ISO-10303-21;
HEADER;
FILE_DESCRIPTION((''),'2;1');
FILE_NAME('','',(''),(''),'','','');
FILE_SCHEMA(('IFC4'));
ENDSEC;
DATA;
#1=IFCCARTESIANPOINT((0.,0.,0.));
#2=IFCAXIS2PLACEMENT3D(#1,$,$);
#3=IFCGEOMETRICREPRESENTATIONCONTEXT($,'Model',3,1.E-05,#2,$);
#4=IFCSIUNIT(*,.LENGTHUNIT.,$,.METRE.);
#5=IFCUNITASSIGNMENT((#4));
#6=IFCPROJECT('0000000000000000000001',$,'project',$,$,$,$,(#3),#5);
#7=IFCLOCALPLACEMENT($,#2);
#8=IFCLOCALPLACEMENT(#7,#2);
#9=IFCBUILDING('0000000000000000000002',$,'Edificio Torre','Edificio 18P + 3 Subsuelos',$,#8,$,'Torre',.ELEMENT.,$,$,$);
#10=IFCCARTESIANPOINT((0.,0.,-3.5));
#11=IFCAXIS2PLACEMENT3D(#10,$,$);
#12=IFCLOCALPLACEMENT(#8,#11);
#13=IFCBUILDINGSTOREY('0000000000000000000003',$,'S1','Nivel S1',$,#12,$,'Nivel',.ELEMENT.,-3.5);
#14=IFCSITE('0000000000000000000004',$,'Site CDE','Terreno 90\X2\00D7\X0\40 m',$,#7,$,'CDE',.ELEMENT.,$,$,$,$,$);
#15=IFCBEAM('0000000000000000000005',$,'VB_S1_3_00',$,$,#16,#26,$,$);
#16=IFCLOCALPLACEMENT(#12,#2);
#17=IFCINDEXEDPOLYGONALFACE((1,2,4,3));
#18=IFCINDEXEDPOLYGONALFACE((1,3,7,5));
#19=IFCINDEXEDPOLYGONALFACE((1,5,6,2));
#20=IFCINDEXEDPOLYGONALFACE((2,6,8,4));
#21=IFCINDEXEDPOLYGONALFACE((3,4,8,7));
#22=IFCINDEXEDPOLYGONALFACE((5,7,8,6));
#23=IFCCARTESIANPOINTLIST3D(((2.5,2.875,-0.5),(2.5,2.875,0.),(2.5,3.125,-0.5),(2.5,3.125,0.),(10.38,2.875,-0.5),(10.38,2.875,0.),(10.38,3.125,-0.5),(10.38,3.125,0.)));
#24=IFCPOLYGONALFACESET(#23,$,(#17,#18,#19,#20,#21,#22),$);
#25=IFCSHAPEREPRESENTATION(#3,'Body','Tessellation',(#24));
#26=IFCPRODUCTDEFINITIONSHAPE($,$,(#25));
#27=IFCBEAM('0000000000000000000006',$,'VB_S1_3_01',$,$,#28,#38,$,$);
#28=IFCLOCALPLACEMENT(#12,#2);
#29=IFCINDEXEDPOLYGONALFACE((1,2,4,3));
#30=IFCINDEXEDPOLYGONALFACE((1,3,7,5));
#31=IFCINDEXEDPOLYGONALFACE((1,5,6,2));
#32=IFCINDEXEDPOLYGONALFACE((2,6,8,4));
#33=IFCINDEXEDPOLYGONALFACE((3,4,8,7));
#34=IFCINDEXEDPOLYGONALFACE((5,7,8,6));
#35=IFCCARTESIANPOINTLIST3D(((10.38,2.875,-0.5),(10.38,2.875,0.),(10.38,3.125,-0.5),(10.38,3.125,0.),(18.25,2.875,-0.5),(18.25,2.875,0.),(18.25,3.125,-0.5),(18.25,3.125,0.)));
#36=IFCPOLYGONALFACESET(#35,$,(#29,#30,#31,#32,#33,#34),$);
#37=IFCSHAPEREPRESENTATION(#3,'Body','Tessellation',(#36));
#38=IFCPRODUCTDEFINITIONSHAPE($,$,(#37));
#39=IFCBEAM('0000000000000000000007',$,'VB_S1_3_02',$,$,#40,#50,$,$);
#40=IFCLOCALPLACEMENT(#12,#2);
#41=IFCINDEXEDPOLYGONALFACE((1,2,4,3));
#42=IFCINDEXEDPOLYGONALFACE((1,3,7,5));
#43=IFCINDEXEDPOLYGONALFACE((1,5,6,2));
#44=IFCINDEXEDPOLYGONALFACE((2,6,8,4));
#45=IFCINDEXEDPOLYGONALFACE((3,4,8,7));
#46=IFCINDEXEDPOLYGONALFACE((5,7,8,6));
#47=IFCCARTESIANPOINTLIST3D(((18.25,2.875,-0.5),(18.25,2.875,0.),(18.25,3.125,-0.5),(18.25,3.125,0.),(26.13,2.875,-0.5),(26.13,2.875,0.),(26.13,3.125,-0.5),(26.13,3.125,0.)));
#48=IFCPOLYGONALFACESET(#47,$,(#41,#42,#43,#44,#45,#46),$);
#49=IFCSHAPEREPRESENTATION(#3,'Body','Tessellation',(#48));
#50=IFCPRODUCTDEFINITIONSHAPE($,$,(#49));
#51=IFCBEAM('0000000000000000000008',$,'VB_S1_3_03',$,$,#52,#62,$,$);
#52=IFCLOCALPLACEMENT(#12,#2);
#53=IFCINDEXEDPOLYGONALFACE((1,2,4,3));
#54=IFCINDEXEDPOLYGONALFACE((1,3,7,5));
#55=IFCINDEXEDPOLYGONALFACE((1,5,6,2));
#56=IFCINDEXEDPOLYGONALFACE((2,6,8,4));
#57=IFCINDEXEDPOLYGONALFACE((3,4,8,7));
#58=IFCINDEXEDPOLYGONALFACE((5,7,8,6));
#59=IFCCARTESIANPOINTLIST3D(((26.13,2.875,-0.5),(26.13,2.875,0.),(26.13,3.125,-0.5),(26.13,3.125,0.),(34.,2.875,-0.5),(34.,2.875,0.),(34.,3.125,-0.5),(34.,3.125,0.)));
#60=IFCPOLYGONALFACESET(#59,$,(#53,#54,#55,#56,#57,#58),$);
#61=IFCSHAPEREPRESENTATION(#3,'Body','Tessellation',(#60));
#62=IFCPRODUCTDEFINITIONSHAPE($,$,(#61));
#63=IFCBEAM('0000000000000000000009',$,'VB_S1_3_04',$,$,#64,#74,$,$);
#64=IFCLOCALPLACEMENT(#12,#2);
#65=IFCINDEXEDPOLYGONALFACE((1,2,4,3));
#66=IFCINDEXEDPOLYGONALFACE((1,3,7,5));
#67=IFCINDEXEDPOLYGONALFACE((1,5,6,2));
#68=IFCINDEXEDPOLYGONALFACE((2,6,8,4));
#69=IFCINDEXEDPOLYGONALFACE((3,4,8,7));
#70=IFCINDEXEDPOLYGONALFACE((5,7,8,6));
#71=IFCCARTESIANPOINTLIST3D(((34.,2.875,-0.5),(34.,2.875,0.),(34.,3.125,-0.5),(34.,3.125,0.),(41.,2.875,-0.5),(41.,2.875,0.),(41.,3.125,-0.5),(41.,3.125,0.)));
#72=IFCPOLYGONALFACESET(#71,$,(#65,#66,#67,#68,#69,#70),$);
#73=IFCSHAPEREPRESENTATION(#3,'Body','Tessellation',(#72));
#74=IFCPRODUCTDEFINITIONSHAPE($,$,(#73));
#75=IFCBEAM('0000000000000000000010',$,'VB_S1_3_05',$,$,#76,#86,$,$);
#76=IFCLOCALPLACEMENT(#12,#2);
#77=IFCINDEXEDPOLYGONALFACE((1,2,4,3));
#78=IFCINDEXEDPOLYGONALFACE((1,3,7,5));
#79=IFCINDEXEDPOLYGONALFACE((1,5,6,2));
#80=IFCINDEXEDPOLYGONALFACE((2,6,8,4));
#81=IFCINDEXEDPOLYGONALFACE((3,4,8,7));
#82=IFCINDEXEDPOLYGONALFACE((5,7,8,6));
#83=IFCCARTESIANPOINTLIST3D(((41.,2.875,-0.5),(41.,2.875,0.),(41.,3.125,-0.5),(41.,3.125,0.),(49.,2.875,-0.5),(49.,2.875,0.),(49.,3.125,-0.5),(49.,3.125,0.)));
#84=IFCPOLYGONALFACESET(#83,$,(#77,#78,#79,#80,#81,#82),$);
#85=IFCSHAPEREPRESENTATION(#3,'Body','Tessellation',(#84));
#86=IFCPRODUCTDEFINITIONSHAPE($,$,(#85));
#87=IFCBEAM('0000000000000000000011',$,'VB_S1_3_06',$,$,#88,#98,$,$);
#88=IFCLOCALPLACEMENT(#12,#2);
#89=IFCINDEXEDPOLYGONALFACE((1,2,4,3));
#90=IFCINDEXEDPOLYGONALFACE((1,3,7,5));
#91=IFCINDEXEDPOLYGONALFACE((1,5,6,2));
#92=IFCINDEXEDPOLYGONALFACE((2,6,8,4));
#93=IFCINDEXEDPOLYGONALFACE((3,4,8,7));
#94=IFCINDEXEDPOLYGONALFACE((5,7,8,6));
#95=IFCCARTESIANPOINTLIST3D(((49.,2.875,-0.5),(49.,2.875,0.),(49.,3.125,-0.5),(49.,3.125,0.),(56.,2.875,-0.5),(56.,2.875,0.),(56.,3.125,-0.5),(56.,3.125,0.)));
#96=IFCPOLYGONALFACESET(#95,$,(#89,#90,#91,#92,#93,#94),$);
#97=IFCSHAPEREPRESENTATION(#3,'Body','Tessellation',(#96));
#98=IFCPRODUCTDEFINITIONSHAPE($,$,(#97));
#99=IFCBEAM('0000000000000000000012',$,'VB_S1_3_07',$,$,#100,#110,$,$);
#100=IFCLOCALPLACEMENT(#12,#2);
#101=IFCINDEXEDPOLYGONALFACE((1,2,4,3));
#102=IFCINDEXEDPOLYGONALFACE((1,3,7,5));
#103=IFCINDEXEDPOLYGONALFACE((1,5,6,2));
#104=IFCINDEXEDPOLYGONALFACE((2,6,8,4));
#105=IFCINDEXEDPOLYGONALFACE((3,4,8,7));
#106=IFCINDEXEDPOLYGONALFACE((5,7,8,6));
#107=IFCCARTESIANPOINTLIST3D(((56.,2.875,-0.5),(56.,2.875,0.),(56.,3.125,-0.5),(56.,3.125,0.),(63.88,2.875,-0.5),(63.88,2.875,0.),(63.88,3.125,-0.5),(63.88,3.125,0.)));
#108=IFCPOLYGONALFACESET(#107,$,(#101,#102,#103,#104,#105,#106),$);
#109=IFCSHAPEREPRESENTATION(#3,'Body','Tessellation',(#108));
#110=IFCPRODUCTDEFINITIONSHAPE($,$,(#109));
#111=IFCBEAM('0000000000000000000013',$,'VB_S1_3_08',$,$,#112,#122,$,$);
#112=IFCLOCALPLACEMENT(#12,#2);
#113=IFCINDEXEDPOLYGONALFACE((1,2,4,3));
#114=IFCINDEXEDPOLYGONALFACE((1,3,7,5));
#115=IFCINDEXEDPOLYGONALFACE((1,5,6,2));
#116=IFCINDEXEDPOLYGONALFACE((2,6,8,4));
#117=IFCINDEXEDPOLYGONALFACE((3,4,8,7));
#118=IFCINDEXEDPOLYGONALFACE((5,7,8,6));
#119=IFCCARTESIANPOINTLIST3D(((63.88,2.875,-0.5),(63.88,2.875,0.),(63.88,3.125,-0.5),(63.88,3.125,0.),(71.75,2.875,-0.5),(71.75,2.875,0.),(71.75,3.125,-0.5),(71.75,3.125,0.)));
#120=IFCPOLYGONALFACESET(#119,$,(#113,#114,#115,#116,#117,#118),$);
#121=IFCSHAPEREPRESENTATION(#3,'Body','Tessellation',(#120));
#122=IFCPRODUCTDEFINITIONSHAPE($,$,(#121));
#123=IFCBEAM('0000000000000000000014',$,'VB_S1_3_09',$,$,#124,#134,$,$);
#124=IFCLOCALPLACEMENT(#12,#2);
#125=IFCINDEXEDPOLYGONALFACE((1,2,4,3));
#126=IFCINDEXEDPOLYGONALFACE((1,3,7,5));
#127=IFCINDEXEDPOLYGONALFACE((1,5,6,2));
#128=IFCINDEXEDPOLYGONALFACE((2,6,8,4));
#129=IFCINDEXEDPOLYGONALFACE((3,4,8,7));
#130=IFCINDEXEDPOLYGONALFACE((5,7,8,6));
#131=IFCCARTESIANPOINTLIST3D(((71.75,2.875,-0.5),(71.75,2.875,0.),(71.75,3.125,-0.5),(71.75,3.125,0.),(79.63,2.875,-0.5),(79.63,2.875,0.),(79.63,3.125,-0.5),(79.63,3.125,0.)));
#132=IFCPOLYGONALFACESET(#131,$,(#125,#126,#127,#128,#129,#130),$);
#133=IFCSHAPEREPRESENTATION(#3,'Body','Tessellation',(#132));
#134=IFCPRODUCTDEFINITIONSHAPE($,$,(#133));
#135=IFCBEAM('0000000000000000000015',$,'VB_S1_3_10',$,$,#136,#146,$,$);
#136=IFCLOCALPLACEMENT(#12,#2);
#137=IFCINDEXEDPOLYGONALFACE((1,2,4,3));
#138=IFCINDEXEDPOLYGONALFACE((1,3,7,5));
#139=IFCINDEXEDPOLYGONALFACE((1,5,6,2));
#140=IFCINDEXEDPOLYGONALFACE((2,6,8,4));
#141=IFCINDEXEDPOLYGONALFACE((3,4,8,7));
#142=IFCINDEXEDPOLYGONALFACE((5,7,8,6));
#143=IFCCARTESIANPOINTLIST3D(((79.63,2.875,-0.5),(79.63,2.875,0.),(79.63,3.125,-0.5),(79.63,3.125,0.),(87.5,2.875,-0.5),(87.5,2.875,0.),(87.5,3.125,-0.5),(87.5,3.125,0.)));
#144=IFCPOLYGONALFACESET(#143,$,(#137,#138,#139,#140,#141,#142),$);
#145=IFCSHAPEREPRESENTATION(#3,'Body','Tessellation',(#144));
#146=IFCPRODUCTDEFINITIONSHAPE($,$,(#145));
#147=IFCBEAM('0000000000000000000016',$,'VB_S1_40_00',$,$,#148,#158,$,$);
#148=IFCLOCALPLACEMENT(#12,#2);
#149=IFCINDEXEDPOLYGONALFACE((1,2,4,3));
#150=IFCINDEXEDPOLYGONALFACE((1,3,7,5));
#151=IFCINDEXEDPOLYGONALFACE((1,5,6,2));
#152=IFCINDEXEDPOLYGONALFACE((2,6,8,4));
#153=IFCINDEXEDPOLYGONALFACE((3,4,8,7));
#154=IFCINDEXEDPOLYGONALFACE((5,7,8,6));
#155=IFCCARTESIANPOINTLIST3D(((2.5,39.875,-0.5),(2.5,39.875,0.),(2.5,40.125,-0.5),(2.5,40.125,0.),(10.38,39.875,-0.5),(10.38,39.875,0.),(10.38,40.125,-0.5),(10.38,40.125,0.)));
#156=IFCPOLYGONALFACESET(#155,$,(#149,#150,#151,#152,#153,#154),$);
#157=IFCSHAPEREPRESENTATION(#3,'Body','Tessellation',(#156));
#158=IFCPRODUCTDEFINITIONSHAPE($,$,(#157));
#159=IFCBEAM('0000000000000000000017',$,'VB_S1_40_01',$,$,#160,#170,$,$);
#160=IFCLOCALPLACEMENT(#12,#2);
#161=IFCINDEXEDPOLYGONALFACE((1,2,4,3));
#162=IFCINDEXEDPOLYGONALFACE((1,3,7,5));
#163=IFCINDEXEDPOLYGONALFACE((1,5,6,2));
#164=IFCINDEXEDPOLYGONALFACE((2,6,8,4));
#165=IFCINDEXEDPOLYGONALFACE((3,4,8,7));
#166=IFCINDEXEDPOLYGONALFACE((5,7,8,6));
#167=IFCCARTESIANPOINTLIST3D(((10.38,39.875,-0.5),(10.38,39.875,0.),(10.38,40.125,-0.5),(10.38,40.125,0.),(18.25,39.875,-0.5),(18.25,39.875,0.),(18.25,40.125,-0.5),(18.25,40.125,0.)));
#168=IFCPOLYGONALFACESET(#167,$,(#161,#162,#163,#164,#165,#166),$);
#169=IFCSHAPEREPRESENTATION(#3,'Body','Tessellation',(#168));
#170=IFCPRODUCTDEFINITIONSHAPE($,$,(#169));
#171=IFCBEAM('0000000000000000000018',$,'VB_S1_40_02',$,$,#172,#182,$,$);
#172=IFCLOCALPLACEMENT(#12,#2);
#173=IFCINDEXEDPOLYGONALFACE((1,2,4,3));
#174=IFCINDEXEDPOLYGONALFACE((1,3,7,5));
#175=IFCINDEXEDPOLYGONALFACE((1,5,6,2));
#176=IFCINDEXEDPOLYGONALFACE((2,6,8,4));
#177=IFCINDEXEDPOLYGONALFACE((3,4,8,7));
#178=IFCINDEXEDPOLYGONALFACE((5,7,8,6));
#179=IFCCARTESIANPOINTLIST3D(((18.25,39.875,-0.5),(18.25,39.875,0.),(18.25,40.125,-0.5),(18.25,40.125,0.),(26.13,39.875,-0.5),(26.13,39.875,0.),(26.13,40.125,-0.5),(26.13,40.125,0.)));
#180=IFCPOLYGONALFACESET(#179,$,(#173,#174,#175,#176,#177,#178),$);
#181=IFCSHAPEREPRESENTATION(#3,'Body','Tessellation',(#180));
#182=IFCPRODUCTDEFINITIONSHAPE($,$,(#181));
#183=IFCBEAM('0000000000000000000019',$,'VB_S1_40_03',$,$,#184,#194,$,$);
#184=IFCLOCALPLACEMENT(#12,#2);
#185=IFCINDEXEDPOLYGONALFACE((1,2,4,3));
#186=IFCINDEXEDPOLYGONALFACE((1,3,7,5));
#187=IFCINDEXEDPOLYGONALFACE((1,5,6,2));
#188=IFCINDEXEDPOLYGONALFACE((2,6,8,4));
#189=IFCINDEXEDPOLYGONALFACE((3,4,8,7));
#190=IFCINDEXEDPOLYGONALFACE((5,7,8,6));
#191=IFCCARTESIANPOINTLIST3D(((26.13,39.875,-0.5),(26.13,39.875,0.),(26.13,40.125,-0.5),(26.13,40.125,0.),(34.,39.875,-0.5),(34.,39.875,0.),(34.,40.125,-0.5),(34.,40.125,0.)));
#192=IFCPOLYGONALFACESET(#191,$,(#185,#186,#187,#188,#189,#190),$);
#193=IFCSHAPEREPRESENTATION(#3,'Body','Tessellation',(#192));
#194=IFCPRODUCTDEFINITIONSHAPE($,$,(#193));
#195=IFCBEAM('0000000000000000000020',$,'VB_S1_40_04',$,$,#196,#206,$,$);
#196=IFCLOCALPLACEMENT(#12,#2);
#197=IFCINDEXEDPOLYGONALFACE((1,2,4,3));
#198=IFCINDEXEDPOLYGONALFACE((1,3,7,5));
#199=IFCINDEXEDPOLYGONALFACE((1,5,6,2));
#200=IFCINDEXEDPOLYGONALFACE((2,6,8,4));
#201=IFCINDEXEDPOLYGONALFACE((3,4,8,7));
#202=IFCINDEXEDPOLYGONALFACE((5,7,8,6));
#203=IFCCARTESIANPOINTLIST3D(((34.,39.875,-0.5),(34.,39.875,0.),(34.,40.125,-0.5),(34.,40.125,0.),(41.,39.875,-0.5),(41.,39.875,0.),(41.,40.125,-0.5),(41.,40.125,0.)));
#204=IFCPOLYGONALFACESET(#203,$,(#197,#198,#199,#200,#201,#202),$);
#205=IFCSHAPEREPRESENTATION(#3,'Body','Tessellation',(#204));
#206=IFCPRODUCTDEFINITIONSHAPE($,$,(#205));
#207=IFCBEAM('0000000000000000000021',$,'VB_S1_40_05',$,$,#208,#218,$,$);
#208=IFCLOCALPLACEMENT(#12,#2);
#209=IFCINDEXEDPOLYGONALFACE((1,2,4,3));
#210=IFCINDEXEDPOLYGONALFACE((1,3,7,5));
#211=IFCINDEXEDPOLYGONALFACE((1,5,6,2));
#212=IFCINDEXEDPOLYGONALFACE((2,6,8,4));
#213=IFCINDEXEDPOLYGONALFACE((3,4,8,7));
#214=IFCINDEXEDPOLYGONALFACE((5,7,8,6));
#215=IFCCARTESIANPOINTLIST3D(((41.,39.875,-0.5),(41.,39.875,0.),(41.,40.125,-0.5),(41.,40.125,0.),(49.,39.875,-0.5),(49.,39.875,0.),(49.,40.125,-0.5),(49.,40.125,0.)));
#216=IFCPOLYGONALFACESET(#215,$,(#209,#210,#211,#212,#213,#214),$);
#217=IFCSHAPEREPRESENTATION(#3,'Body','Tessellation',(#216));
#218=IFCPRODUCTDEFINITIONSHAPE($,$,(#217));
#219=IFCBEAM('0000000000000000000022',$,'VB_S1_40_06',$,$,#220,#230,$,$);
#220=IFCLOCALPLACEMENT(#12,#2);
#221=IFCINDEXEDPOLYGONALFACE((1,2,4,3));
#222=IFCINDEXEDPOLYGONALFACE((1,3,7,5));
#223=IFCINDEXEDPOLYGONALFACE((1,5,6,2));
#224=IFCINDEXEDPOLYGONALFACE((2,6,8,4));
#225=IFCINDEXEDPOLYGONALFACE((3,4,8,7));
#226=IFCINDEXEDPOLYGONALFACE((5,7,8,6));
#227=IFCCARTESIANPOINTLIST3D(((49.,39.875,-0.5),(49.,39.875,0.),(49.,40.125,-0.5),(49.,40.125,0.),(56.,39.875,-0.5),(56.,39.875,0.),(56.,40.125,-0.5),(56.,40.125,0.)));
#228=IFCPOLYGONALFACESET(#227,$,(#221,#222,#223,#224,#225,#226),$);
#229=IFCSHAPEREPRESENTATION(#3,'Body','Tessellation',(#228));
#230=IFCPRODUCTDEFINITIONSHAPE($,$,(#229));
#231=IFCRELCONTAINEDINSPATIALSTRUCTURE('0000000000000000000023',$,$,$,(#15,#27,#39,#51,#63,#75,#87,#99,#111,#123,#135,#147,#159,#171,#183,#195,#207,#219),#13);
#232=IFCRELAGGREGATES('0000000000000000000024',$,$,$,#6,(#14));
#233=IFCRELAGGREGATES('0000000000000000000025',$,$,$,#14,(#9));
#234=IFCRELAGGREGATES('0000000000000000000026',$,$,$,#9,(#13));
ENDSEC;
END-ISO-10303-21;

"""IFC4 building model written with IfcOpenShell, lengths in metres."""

from ifc_helpers import new_model, si_unit, frame, origin, origin_2d, place, context, project, spatial, rectangle, extrude, element, save


model = new_model("IFC4")

# Units and contexts
model_context = context("Model", 3, precision=1e-05, world=origin())
ifc_project = project(units=[si_unit("LENGTHUNIT", "METRE")], contexts=[model_context])

# Site, building, storey
site_placement = place(None, origin())
site = spatial("IfcSite", under=ifc_project, at=site_placement, Name="Site CDE", Description="Terreno 90×40 m", LongName="CDE", CompositionType="ELEMENT")
building_placement = place(site_placement, origin())
building = spatial("IfcBuilding", under=site, at=building_placement, Name="Edificio Torre", Description="Edificio 18P + 3 Subsuelos", LongName="Torre", CompositionType="ELEMENT")
storey_placement = place(building_placement, frame((0.0, 0.0, -3.5)))
storey = spatial("IfcBuildingStorey", under=building, at=storey_placement, Name="S1", Description="Nivel S1", LongName="Nivel", CompositionType="ELEMENT", Elevation=-3.5)

# Beams
beam_1_placement = place(storey_placement, frame((6.44, 3.0, -0.5)))
element("IfcBeam", 1, at=beam_1_placement, inside=storey, Name="VB_S1_3_00", context=model_context, shape_type="SweptSolid", body=[
    extrude(rectangle(XDim=7.88, YDim=0.25, at=origin_2d()), origin(), (0.0, 0.0, 1.0), 0.5),
])
beam_2_placement = place(storey_placement, frame((14.315, 3.0, -0.5)))
element("IfcBeam", 2, at=beam_2_placement, inside=storey, Name="VB_S1_3_01", context=model_context, shape_type="SweptSolid", body=[
    extrude(rectangle(XDim=7.87, YDim=0.25, at=origin_2d()), origin(), (0.0, 0.0, 1.0), 0.5),
])
beam_3_placement = place(storey_placement, frame((22.19, 3.0, -0.5)))
element("IfcBeam", 3, at=beam_3_placement, inside=storey, Name="VB_S1_3_02", context=model_context, shape_type="SweptSolid", body=[
    extrude(rectangle(XDim=7.88, YDim=0.25, at=origin_2d()), origin(), (0.0, 0.0, 1.0), 0.5),
])
beam_4_placement = place(storey_placement, frame((30.065, 3.0, -0.5)))
element("IfcBeam", 4, at=beam_4_placement, inside=storey, Name="VB_S1_3_03", context=model_context, shape_type="SweptSolid", body=[
    extrude(rectangle(XDim=7.87, YDim=0.25, at=origin_2d()), origin(), (0.0, 0.0, 1.0), 0.5),
])
beam_5_placement = place(storey_placement, frame((37.5, 3.0, -0.5)))
element("IfcBeam", 5, at=beam_5_placement, inside=storey, Name="VB_S1_3_04", context=model_context, shape_type="SweptSolid", body=[
    extrude(rectangle(XDim=7.0, YDim=0.25, at=origin_2d()), origin(), (0.0, 0.0, 1.0), 0.5),
])
beam_6_placement = place(storey_placement, frame((45.0, 3.0, -0.5)))
element("IfcBeam", 6, at=beam_6_placement, inside=storey, Name="VB_S1_3_05", context=model_context, shape_type="SweptSolid", body=[
    extrude(rectangle(XDim=8.0, YDim=0.25, at=origin_2d()), origin(), (0.0, 0.0, 1.0), 0.5),
])
beam_7_placement = place(storey_placement, frame((52.5, 3.0, -0.5)))
element("IfcBeam", 7, at=beam_7_placement, inside=storey, Name="VB_S1_3_06", context=model_context, shape_type="SweptSolid", body=[
    extrude(rectangle(XDim=7.0, YDim=0.25, at=origin_2d()), origin(), (0.0, 0.0, 1.0), 0.5),
])
beam_8_placement = place(storey_placement, frame((59.94, 3.0, -0.5)))
element("IfcBeam", 8, at=beam_8_placement, inside=storey, Name="VB_S1_3_07", context=model_context, shape_type="SweptSolid", body=[
    extrude(rectangle(XDim=7.88, YDim=0.25, at=origin_2d()), origin(), (0.0, 0.0, 1.0), 0.5),
])
beam_9_placement = place(storey_placement, frame((67.815, 3.0, -0.5)))
element("IfcBeam", 9, at=beam_9_placement, inside=storey, Name="VB_S1_3_08", context=model_context, shape_type="SweptSolid", body=[
    extrude(rectangle(XDim=7.87, YDim=0.25, at=origin_2d()), origin(), (0.0, 0.0, 1.0), 0.5),
])
beam_10_placement = place(storey_placement, frame((75.69, 3.0, -0.5)))
element("IfcBeam", 10, at=beam_10_placement, inside=storey, Name="VB_S1_3_09", context=model_context, shape_type="SweptSolid", body=[
    extrude(rectangle(XDim=7.88, YDim=0.25, at=origin_2d()), origin(), (0.0, 0.0, 1.0), 0.5),
])
beam_11_placement = place(storey_placement, frame((83.565, 3.0, -0.5)))
element("IfcBeam", 11, at=beam_11_placement, inside=storey, Name="VB_S1_3_10", context=model_context, shape_type="SweptSolid", body=[
    extrude(rectangle(XDim=7.87, YDim=0.25, at=origin_2d()), origin(), (0.0, 0.0, 1.0), 0.5),
])
beam_12_placement = place(storey_placement, frame((6.44, 40.0, -0.5)))
element("IfcBeam", 12, at=beam_12_placement, inside=storey, Name="VB_S1_40_00", context=model_context, shape_type="SweptSolid", body=[
    extrude(rectangle(XDim=7.88, YDim=0.25, at=origin_2d()), origin(), (0.0, 0.0, 1.0), 0.5),
])
beam_13_placement = place(storey_placement, frame((14.315, 40.0, -0.5)))
element("IfcBeam", 13, at=beam_13_placement, inside=storey, Name="VB_S1_40_01", context=model_context, shape_type="SweptSolid", body=[
    extrude(rectangle(XDim=7.87, YDim=0.25, at=origin_2d()), origin(), (0.0, 0.0, 1.0), 0.5),
])
beam_14_placement = place(storey_placement, frame((22.19, 40.0, -0.5)))
element("IfcBeam", 14, at=beam_14_placement, inside=storey, Name="VB_S1_40_02", context=model_context, shape_type="SweptSolid", body=[
    extrude(rectangle(XDim=7.88, YDim=0.25, at=origin_2d()), origin(), (0.0, 0.0, 1.0), 0.5),
])
beam_15_placement = place(storey_placement, frame((30.065, 40.0, -0.5)))
element("IfcBeam", 15, at=beam_15_placement, inside=storey, Name="VB_S1_40_03", context=model_context, shape_type="SweptSolid", body=[
    extrude(rectangle(XDim=7.87, YDim=0.25, at=origin_2d()), origin(), (0.0, 0.0, 1.0), 0.5),
])
beam_16_placement = place(storey_placement, frame((37.5, 40.0, -0.5)))
element("IfcBeam", 16, at=beam_16_placement, inside=storey, Name="VB_S1_40_04", context=model_context, shape_type="SweptSolid", body=[
    extrude(rectangle(XDim=7.0, YDim=0.25, at=origin_2d()), origin(), (0.0, 0.0, 1.0), 0.5),
])
beam_17_placement = place(storey_placement, frame((45.0, 40.0, -0.5)))
element("IfcBeam", 17, at=beam_17_placement, inside=storey, Name="VB_S1_40_05", context=model_context, shape_type="SweptSolid", body=[
    extrude(rectangle(XDim=8.0, YDim=0.25, at=origin_2d()), origin(), (0.0, 0.0, 1.0), 0.5),
])
beam_18_placement = place(storey_placement, frame((52.5, 40.0, -0.5)))
element("IfcBeam", 18, at=beam_18_placement, inside=storey, Name="VB_S1_40_06", context=model_context, shape_type="SweptSolid", body=[
    extrude(rectangle(XDim=7.0, YDim=0.25, at=origin_2d()), origin(), (0.0, 0.0, 1.0), 0.5),
])

save(model, "model.ifc")
